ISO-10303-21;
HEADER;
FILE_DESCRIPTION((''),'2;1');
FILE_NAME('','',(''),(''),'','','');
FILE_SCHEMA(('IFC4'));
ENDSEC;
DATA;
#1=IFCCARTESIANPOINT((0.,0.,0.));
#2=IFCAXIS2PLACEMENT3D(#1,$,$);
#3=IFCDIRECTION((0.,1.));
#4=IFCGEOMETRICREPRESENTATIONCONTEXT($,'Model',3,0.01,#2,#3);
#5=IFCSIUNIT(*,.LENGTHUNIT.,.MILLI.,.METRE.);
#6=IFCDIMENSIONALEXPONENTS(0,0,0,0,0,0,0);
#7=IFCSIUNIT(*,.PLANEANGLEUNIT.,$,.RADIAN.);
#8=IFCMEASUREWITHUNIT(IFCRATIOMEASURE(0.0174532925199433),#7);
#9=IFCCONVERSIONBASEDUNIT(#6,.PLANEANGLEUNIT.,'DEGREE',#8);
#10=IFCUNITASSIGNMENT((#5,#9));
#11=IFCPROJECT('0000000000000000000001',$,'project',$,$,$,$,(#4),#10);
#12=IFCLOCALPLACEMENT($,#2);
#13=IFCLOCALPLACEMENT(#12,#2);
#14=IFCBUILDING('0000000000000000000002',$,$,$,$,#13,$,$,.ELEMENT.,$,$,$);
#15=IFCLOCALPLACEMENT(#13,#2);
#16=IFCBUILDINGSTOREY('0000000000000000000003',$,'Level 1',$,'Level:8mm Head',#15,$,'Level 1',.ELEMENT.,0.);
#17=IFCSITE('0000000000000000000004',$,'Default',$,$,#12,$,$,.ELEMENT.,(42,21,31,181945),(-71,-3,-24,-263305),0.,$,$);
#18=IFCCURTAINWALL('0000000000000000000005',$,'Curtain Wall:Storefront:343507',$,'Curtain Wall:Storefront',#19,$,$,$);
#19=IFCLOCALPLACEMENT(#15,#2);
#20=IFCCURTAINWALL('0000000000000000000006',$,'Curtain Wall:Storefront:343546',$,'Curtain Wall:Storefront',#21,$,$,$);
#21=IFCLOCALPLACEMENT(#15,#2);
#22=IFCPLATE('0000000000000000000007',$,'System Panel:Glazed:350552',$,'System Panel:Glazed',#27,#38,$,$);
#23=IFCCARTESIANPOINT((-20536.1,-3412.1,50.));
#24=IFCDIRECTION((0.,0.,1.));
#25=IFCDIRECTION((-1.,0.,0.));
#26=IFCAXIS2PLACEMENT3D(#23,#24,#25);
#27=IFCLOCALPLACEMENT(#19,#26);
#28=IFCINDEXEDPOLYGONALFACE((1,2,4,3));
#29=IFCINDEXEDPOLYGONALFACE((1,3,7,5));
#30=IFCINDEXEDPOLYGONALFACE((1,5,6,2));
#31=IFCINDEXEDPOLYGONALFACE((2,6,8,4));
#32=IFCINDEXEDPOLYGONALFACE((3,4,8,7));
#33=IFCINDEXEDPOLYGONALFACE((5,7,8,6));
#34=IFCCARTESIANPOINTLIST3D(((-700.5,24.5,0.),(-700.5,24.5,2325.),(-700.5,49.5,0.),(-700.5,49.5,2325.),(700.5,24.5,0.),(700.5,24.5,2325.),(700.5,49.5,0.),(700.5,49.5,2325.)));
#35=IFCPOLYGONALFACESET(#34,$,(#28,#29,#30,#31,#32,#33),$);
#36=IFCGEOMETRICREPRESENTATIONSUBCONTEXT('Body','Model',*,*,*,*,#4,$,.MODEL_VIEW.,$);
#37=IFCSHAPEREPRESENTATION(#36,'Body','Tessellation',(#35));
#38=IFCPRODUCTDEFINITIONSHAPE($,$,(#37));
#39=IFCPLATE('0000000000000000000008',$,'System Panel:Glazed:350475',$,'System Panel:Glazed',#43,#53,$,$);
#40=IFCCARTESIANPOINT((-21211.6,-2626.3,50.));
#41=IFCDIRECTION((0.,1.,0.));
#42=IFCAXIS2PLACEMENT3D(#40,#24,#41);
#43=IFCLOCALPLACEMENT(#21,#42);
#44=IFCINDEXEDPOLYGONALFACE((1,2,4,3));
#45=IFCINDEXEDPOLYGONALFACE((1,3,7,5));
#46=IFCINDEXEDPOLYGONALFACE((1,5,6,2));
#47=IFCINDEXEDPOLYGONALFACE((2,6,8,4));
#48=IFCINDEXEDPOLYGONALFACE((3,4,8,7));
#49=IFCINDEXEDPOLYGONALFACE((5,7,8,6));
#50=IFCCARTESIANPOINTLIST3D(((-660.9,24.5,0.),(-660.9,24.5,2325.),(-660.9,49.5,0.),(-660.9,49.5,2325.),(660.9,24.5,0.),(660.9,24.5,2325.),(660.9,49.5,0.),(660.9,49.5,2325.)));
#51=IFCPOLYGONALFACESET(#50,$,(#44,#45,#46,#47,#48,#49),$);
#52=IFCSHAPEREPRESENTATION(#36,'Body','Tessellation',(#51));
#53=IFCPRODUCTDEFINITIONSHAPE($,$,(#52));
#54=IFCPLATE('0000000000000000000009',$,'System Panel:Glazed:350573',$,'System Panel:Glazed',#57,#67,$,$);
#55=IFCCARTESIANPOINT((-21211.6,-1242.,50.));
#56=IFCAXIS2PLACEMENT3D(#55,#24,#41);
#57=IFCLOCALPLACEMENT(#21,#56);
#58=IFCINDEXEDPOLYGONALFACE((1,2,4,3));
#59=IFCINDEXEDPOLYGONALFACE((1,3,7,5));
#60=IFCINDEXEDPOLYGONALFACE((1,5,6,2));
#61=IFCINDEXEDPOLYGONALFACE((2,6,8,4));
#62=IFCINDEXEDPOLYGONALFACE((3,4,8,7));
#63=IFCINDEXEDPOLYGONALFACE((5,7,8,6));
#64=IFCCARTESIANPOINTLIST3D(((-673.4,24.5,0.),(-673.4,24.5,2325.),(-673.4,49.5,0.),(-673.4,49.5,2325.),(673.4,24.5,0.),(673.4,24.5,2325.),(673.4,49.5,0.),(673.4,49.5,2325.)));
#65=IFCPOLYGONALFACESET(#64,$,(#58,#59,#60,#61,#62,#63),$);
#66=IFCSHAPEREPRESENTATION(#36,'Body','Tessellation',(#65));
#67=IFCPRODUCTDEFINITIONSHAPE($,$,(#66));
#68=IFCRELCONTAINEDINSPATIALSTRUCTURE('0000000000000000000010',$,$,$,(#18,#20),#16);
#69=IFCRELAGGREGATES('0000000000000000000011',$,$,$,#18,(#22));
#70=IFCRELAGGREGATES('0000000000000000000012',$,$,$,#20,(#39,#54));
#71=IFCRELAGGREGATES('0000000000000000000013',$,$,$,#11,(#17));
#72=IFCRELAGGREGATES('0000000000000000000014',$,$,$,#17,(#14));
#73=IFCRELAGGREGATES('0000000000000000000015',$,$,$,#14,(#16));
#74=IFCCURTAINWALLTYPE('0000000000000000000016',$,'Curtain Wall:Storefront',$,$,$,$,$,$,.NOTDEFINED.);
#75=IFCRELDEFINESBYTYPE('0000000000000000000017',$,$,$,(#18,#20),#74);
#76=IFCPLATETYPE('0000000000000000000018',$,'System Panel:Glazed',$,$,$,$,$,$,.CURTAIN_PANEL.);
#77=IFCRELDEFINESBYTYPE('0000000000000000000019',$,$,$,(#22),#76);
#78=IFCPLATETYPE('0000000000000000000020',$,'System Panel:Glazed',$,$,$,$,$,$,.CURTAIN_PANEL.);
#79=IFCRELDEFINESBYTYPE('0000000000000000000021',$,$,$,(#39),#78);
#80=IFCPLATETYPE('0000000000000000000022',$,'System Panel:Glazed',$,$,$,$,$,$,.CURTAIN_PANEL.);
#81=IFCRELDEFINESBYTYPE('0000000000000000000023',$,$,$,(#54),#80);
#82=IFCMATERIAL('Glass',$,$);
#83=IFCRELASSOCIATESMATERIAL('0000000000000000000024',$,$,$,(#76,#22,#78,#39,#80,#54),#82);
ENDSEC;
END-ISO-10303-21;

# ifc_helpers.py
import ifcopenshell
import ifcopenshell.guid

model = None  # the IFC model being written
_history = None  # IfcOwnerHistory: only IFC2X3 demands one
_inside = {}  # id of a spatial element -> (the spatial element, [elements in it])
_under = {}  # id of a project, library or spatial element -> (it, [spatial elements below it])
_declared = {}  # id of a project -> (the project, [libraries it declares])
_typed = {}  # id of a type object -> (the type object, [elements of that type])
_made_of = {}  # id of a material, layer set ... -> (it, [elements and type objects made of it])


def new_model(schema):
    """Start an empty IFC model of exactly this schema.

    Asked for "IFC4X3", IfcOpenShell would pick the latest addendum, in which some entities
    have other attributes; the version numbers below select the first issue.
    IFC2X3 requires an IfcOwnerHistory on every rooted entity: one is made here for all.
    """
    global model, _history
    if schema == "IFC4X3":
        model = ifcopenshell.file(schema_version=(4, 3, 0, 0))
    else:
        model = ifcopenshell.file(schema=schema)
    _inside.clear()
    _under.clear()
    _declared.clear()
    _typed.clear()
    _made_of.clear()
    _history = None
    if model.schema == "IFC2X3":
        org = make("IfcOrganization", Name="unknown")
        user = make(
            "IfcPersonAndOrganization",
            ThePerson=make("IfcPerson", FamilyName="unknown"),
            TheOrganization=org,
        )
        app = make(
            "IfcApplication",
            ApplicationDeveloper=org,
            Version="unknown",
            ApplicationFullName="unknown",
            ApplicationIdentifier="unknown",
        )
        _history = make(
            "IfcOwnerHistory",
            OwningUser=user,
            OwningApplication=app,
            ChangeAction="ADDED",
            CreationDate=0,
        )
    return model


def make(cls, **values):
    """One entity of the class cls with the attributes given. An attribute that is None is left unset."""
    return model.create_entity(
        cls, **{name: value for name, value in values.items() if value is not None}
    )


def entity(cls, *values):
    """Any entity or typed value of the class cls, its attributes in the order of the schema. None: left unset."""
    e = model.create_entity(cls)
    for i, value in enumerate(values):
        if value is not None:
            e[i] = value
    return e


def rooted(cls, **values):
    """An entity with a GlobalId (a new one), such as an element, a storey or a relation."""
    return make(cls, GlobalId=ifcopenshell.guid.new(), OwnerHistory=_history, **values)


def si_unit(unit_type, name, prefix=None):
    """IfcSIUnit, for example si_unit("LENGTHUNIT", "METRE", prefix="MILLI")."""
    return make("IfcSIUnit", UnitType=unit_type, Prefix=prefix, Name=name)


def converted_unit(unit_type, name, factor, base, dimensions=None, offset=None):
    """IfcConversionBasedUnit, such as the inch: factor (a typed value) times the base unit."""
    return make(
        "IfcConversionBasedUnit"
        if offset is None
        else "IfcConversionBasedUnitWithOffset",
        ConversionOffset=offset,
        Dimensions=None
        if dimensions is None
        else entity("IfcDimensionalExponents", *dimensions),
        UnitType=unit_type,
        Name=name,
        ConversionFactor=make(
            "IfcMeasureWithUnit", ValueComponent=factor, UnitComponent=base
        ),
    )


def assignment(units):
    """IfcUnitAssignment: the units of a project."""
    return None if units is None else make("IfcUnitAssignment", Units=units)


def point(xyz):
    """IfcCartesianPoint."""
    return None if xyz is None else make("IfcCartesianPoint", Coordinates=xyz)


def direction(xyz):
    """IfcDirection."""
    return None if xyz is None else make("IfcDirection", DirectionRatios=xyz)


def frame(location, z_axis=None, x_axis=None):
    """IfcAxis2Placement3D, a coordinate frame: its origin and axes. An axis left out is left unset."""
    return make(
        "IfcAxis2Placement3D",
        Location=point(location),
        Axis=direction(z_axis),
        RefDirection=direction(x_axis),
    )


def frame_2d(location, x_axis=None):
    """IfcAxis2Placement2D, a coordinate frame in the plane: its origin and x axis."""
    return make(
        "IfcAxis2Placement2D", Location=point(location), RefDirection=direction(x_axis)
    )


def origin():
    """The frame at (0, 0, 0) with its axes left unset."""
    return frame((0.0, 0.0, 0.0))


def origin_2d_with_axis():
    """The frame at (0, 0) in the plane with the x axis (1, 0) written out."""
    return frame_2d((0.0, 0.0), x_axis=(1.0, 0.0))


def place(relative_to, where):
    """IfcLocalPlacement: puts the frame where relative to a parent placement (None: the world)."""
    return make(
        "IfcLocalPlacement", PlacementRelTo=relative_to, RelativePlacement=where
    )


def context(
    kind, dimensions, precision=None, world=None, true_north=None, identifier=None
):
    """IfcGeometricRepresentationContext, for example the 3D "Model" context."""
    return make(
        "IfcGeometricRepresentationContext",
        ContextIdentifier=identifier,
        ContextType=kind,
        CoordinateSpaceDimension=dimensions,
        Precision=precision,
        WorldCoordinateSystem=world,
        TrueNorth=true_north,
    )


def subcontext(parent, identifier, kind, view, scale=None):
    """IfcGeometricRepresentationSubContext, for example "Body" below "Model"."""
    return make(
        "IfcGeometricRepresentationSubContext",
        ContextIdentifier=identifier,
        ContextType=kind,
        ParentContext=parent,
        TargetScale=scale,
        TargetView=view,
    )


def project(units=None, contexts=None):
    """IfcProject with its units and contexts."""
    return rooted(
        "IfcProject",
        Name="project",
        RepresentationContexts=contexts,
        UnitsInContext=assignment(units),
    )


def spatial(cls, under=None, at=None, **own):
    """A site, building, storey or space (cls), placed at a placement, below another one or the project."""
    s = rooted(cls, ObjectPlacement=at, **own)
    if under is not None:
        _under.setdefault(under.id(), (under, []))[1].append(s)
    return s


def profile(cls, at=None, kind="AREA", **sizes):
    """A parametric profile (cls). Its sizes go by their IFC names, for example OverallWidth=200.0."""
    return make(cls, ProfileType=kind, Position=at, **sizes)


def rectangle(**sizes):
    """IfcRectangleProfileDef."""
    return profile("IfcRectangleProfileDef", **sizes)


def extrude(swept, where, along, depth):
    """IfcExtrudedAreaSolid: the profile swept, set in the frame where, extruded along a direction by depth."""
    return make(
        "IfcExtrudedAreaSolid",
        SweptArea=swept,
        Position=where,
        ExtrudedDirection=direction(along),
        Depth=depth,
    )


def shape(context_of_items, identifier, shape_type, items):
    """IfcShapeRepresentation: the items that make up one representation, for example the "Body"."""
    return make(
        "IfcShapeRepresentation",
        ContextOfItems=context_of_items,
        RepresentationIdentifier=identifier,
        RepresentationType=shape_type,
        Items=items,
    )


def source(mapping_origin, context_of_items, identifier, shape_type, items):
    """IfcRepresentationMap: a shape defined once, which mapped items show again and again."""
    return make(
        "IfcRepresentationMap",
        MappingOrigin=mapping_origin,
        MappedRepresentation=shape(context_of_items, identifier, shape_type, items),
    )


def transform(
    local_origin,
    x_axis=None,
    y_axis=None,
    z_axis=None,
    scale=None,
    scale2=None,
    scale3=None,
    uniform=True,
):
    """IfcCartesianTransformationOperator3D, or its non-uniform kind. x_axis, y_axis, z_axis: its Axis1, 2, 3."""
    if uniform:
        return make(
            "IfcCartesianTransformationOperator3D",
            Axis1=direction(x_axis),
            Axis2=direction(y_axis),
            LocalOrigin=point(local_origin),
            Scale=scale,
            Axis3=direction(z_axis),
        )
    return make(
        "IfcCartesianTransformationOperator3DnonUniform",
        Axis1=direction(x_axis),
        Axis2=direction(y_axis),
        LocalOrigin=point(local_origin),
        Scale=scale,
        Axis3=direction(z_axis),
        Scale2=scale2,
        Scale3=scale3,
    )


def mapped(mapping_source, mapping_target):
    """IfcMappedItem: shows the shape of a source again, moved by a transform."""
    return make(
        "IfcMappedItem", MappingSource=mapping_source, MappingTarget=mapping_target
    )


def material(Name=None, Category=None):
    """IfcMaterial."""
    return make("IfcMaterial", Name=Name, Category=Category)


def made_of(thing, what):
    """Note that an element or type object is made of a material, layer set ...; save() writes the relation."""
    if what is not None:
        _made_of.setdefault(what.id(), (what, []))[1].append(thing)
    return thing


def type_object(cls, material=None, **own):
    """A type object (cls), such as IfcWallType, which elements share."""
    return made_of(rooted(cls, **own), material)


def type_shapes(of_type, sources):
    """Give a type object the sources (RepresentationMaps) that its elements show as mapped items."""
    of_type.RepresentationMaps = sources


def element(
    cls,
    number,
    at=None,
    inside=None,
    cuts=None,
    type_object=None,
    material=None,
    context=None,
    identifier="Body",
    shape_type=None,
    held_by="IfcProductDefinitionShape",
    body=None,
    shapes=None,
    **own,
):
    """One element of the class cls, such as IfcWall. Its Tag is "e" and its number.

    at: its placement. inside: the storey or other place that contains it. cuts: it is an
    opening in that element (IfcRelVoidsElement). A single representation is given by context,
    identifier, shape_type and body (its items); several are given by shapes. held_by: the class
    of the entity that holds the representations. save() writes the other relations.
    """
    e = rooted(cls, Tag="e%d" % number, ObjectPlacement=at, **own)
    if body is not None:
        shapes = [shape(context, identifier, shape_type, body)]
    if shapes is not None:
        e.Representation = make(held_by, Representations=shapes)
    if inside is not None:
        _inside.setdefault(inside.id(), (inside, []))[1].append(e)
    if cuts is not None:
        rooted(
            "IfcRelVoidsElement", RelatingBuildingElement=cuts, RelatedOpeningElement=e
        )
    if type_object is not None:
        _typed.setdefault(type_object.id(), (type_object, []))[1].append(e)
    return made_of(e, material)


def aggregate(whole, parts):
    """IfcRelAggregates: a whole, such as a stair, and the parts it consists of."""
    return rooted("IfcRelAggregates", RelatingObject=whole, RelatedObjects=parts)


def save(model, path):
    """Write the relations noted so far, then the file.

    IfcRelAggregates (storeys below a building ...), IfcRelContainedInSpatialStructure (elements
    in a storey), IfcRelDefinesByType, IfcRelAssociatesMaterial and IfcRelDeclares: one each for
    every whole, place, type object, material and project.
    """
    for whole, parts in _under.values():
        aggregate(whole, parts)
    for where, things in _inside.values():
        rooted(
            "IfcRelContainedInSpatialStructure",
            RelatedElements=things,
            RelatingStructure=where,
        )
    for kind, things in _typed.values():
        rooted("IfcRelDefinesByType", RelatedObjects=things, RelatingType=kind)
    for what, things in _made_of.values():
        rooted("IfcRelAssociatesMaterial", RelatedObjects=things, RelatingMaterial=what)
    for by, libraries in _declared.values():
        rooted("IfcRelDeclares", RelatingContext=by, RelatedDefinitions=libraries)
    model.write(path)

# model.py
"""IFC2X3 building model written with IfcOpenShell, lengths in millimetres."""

from ifc_helpers import new_model, entity, si_unit, converted_unit, direction, frame, origin, origin_2d_with_axis, place, context, subcontext, project, spatial, rectangle, extrude, source, transform, mapped, material, type_object, type_shapes, element, aggregate, save


model = new_model("IFC2X3")

# Units and contexts
model_context = context("Model", 3, precision=0.01, world=origin(), true_north=direction((0.0, 1.0)))
body_context = subcontext(model_context, "Body", "Model", "MODEL_VIEW")
ifc_project = project(units=[si_unit("LENGTHUNIT", "METRE", prefix="MILLI"), converted_unit("PLANEANGLEUNIT", "DEGREE", entity("IfcRatioMeasure", 0.0174532925199433), si_unit("PLANEANGLEUNIT", "RADIAN"), dimensions=[0, 0, 0, 0, 0, 0, 0])], contexts=[model_context])

# Site, building, storey
site_placement = place(None, frame((0.0, 0.0, 0.0)))
site = spatial("IfcSite", under=ifc_project, at=site_placement, Name="Default", CompositionType="ELEMENT", RefLatitude=(42, 21, 31, 181945), RefLongitude=(-71, -3, -24, -263305), RefElevation=0.0)
building_placement = place(site_placement, origin())
building = spatial("IfcBuilding", under=site, at=building_placement, CompositionType="ELEMENT")
storey_placement = place(building_placement, origin())
storey = spatial("IfcBuildingStorey", under=building, at=storey_placement, Name="Level 1", ObjectType="Level:8mm Head", LongName="Level 1", CompositionType="ELEMENT", Elevation=0.0)

# Curtain wall
curtain_wall_type = type_object("IfcCurtainWallType", Name="Curtain Wall:Storefront", PredefinedType="NOTDEFINED")
curtain_wall_1_placement = place(storey_placement, origin())
curtain_wall_1 = element("IfcCurtainWall", 1, at=curtain_wall_1_placement, inside=storey, type_object=curtain_wall_type, Name="Curtain Wall:Storefront:343507", ObjectType="Curtain Wall:Storefront")

# Curtain wall
curtain_wall_2_placement = place(storey_placement, origin())
curtain_wall_2 = element("IfcCurtainWall", 2, at=curtain_wall_2_placement, inside=storey, type_object=curtain_wall_type, Name="Curtain Wall:Storefront:343546", ObjectType="Curtain Wall:Storefront")

# Plates
ifc_material_1 = material(Name="Glass")
plate_type_1 = type_object("IfcPlateType", Name="System Panel:Glazed", PredefinedType="CURTAIN_PANEL", material=ifc_material_1)
shared_shape_1 = source(origin(), body_context, "Body", "SweptSolid", [
    extrude(rectangle(XDim=25.0, YDim=1401.0, at=origin_2d_with_axis()), frame((0.0, 37.0, 0.0), z_axis=(0.0, 0.0, 1.0), x_axis=(0.0, 1.0, 0.0)), (0.0, 0.0, 1.0), 2325.0),
])
type_shapes(plate_type_1, [shared_shape_1])
plate_1_placement = place(curtain_wall_1_placement, frame((-20536.1, -3412.1, 50.0), z_axis=(0.0, 0.0, 1.0), x_axis=(-1.0, 0.0, 0.0)))
plate_1 = element("IfcPlate", 3, at=plate_1_placement, type_object=plate_type_1, material=ifc_material_1, Name="System Panel:Glazed:350552", ObjectType="System Panel:Glazed", context=body_context, shape_type="MappedRepresentation", body=[
    mapped(shared_shape_1, transform((0.0, 0.0, 0.0), scale=1.0)),
])
aggregate(curtain_wall_1, [plate_1])
plate_type_2 = type_object("IfcPlateType", Name="System Panel:Glazed", PredefinedType="CURTAIN_PANEL", material=ifc_material_1)
shared_shape_2 = source(origin(), body_context, "Body", "SweptSolid", [
    extrude(rectangle(XDim=25.0, YDim=1321.7, at=origin_2d_with_axis()), frame((0.0, 37.0, 0.0), z_axis=(0.0, 0.0, 1.0), x_axis=(0.0, 1.0, 0.0)), (0.0, 0.0, 1.0), 2325.0),
])
type_shapes(plate_type_2, [shared_shape_2])
plate_2_placement = place(curtain_wall_2_placement, frame((-21211.6, -2626.3, 50.0), z_axis=(0.0, 0.0, 1.0), x_axis=(0.0, 1.0, 0.0)))
plate_2 = element("IfcPlate", 4, at=plate_2_placement, type_object=plate_type_2, material=ifc_material_1, Name="System Panel:Glazed:350475", ObjectType="System Panel:Glazed", context=body_context, shape_type="MappedRepresentation", body=[
    mapped(shared_shape_2, transform((0.0, 0.0, 0.0), scale=1.0)),
])
plate_type_3 = type_object("IfcPlateType", Name="System Panel:Glazed", PredefinedType="CURTAIN_PANEL", material=ifc_material_1)
shared_shape_3 = source(origin(), body_context, "Body", "SweptSolid", [
    extrude(rectangle(XDim=25.0, YDim=1346.7, at=origin_2d_with_axis()), frame((0.0, 37.0, 0.0), z_axis=(0.0, 0.0, 1.0), x_axis=(0.0, 1.0, 0.0)), (0.0, 0.0, 1.0), 2325.0),
])
type_shapes(plate_type_3, [shared_shape_3])
plate_3_placement = place(curtain_wall_2_placement, frame((-21211.6, -1242.0, 50.0), z_axis=(0.0, 0.0, 1.0), x_axis=(0.0, 1.0, 0.0)))
plate_3 = element("IfcPlate", 5, at=plate_3_placement, type_object=plate_type_3, material=ifc_material_1, Name="System Panel:Glazed:350573", ObjectType="System Panel:Glazed", context=body_context, shape_type="MappedRepresentation", body=[
    mapped(shared_shape_3, transform((0.0, 0.0, 0.0), scale=1.0)),
])
aggregate(curtain_wall_2, [plate_2, plate_3])

save(model, "model.ifc")
